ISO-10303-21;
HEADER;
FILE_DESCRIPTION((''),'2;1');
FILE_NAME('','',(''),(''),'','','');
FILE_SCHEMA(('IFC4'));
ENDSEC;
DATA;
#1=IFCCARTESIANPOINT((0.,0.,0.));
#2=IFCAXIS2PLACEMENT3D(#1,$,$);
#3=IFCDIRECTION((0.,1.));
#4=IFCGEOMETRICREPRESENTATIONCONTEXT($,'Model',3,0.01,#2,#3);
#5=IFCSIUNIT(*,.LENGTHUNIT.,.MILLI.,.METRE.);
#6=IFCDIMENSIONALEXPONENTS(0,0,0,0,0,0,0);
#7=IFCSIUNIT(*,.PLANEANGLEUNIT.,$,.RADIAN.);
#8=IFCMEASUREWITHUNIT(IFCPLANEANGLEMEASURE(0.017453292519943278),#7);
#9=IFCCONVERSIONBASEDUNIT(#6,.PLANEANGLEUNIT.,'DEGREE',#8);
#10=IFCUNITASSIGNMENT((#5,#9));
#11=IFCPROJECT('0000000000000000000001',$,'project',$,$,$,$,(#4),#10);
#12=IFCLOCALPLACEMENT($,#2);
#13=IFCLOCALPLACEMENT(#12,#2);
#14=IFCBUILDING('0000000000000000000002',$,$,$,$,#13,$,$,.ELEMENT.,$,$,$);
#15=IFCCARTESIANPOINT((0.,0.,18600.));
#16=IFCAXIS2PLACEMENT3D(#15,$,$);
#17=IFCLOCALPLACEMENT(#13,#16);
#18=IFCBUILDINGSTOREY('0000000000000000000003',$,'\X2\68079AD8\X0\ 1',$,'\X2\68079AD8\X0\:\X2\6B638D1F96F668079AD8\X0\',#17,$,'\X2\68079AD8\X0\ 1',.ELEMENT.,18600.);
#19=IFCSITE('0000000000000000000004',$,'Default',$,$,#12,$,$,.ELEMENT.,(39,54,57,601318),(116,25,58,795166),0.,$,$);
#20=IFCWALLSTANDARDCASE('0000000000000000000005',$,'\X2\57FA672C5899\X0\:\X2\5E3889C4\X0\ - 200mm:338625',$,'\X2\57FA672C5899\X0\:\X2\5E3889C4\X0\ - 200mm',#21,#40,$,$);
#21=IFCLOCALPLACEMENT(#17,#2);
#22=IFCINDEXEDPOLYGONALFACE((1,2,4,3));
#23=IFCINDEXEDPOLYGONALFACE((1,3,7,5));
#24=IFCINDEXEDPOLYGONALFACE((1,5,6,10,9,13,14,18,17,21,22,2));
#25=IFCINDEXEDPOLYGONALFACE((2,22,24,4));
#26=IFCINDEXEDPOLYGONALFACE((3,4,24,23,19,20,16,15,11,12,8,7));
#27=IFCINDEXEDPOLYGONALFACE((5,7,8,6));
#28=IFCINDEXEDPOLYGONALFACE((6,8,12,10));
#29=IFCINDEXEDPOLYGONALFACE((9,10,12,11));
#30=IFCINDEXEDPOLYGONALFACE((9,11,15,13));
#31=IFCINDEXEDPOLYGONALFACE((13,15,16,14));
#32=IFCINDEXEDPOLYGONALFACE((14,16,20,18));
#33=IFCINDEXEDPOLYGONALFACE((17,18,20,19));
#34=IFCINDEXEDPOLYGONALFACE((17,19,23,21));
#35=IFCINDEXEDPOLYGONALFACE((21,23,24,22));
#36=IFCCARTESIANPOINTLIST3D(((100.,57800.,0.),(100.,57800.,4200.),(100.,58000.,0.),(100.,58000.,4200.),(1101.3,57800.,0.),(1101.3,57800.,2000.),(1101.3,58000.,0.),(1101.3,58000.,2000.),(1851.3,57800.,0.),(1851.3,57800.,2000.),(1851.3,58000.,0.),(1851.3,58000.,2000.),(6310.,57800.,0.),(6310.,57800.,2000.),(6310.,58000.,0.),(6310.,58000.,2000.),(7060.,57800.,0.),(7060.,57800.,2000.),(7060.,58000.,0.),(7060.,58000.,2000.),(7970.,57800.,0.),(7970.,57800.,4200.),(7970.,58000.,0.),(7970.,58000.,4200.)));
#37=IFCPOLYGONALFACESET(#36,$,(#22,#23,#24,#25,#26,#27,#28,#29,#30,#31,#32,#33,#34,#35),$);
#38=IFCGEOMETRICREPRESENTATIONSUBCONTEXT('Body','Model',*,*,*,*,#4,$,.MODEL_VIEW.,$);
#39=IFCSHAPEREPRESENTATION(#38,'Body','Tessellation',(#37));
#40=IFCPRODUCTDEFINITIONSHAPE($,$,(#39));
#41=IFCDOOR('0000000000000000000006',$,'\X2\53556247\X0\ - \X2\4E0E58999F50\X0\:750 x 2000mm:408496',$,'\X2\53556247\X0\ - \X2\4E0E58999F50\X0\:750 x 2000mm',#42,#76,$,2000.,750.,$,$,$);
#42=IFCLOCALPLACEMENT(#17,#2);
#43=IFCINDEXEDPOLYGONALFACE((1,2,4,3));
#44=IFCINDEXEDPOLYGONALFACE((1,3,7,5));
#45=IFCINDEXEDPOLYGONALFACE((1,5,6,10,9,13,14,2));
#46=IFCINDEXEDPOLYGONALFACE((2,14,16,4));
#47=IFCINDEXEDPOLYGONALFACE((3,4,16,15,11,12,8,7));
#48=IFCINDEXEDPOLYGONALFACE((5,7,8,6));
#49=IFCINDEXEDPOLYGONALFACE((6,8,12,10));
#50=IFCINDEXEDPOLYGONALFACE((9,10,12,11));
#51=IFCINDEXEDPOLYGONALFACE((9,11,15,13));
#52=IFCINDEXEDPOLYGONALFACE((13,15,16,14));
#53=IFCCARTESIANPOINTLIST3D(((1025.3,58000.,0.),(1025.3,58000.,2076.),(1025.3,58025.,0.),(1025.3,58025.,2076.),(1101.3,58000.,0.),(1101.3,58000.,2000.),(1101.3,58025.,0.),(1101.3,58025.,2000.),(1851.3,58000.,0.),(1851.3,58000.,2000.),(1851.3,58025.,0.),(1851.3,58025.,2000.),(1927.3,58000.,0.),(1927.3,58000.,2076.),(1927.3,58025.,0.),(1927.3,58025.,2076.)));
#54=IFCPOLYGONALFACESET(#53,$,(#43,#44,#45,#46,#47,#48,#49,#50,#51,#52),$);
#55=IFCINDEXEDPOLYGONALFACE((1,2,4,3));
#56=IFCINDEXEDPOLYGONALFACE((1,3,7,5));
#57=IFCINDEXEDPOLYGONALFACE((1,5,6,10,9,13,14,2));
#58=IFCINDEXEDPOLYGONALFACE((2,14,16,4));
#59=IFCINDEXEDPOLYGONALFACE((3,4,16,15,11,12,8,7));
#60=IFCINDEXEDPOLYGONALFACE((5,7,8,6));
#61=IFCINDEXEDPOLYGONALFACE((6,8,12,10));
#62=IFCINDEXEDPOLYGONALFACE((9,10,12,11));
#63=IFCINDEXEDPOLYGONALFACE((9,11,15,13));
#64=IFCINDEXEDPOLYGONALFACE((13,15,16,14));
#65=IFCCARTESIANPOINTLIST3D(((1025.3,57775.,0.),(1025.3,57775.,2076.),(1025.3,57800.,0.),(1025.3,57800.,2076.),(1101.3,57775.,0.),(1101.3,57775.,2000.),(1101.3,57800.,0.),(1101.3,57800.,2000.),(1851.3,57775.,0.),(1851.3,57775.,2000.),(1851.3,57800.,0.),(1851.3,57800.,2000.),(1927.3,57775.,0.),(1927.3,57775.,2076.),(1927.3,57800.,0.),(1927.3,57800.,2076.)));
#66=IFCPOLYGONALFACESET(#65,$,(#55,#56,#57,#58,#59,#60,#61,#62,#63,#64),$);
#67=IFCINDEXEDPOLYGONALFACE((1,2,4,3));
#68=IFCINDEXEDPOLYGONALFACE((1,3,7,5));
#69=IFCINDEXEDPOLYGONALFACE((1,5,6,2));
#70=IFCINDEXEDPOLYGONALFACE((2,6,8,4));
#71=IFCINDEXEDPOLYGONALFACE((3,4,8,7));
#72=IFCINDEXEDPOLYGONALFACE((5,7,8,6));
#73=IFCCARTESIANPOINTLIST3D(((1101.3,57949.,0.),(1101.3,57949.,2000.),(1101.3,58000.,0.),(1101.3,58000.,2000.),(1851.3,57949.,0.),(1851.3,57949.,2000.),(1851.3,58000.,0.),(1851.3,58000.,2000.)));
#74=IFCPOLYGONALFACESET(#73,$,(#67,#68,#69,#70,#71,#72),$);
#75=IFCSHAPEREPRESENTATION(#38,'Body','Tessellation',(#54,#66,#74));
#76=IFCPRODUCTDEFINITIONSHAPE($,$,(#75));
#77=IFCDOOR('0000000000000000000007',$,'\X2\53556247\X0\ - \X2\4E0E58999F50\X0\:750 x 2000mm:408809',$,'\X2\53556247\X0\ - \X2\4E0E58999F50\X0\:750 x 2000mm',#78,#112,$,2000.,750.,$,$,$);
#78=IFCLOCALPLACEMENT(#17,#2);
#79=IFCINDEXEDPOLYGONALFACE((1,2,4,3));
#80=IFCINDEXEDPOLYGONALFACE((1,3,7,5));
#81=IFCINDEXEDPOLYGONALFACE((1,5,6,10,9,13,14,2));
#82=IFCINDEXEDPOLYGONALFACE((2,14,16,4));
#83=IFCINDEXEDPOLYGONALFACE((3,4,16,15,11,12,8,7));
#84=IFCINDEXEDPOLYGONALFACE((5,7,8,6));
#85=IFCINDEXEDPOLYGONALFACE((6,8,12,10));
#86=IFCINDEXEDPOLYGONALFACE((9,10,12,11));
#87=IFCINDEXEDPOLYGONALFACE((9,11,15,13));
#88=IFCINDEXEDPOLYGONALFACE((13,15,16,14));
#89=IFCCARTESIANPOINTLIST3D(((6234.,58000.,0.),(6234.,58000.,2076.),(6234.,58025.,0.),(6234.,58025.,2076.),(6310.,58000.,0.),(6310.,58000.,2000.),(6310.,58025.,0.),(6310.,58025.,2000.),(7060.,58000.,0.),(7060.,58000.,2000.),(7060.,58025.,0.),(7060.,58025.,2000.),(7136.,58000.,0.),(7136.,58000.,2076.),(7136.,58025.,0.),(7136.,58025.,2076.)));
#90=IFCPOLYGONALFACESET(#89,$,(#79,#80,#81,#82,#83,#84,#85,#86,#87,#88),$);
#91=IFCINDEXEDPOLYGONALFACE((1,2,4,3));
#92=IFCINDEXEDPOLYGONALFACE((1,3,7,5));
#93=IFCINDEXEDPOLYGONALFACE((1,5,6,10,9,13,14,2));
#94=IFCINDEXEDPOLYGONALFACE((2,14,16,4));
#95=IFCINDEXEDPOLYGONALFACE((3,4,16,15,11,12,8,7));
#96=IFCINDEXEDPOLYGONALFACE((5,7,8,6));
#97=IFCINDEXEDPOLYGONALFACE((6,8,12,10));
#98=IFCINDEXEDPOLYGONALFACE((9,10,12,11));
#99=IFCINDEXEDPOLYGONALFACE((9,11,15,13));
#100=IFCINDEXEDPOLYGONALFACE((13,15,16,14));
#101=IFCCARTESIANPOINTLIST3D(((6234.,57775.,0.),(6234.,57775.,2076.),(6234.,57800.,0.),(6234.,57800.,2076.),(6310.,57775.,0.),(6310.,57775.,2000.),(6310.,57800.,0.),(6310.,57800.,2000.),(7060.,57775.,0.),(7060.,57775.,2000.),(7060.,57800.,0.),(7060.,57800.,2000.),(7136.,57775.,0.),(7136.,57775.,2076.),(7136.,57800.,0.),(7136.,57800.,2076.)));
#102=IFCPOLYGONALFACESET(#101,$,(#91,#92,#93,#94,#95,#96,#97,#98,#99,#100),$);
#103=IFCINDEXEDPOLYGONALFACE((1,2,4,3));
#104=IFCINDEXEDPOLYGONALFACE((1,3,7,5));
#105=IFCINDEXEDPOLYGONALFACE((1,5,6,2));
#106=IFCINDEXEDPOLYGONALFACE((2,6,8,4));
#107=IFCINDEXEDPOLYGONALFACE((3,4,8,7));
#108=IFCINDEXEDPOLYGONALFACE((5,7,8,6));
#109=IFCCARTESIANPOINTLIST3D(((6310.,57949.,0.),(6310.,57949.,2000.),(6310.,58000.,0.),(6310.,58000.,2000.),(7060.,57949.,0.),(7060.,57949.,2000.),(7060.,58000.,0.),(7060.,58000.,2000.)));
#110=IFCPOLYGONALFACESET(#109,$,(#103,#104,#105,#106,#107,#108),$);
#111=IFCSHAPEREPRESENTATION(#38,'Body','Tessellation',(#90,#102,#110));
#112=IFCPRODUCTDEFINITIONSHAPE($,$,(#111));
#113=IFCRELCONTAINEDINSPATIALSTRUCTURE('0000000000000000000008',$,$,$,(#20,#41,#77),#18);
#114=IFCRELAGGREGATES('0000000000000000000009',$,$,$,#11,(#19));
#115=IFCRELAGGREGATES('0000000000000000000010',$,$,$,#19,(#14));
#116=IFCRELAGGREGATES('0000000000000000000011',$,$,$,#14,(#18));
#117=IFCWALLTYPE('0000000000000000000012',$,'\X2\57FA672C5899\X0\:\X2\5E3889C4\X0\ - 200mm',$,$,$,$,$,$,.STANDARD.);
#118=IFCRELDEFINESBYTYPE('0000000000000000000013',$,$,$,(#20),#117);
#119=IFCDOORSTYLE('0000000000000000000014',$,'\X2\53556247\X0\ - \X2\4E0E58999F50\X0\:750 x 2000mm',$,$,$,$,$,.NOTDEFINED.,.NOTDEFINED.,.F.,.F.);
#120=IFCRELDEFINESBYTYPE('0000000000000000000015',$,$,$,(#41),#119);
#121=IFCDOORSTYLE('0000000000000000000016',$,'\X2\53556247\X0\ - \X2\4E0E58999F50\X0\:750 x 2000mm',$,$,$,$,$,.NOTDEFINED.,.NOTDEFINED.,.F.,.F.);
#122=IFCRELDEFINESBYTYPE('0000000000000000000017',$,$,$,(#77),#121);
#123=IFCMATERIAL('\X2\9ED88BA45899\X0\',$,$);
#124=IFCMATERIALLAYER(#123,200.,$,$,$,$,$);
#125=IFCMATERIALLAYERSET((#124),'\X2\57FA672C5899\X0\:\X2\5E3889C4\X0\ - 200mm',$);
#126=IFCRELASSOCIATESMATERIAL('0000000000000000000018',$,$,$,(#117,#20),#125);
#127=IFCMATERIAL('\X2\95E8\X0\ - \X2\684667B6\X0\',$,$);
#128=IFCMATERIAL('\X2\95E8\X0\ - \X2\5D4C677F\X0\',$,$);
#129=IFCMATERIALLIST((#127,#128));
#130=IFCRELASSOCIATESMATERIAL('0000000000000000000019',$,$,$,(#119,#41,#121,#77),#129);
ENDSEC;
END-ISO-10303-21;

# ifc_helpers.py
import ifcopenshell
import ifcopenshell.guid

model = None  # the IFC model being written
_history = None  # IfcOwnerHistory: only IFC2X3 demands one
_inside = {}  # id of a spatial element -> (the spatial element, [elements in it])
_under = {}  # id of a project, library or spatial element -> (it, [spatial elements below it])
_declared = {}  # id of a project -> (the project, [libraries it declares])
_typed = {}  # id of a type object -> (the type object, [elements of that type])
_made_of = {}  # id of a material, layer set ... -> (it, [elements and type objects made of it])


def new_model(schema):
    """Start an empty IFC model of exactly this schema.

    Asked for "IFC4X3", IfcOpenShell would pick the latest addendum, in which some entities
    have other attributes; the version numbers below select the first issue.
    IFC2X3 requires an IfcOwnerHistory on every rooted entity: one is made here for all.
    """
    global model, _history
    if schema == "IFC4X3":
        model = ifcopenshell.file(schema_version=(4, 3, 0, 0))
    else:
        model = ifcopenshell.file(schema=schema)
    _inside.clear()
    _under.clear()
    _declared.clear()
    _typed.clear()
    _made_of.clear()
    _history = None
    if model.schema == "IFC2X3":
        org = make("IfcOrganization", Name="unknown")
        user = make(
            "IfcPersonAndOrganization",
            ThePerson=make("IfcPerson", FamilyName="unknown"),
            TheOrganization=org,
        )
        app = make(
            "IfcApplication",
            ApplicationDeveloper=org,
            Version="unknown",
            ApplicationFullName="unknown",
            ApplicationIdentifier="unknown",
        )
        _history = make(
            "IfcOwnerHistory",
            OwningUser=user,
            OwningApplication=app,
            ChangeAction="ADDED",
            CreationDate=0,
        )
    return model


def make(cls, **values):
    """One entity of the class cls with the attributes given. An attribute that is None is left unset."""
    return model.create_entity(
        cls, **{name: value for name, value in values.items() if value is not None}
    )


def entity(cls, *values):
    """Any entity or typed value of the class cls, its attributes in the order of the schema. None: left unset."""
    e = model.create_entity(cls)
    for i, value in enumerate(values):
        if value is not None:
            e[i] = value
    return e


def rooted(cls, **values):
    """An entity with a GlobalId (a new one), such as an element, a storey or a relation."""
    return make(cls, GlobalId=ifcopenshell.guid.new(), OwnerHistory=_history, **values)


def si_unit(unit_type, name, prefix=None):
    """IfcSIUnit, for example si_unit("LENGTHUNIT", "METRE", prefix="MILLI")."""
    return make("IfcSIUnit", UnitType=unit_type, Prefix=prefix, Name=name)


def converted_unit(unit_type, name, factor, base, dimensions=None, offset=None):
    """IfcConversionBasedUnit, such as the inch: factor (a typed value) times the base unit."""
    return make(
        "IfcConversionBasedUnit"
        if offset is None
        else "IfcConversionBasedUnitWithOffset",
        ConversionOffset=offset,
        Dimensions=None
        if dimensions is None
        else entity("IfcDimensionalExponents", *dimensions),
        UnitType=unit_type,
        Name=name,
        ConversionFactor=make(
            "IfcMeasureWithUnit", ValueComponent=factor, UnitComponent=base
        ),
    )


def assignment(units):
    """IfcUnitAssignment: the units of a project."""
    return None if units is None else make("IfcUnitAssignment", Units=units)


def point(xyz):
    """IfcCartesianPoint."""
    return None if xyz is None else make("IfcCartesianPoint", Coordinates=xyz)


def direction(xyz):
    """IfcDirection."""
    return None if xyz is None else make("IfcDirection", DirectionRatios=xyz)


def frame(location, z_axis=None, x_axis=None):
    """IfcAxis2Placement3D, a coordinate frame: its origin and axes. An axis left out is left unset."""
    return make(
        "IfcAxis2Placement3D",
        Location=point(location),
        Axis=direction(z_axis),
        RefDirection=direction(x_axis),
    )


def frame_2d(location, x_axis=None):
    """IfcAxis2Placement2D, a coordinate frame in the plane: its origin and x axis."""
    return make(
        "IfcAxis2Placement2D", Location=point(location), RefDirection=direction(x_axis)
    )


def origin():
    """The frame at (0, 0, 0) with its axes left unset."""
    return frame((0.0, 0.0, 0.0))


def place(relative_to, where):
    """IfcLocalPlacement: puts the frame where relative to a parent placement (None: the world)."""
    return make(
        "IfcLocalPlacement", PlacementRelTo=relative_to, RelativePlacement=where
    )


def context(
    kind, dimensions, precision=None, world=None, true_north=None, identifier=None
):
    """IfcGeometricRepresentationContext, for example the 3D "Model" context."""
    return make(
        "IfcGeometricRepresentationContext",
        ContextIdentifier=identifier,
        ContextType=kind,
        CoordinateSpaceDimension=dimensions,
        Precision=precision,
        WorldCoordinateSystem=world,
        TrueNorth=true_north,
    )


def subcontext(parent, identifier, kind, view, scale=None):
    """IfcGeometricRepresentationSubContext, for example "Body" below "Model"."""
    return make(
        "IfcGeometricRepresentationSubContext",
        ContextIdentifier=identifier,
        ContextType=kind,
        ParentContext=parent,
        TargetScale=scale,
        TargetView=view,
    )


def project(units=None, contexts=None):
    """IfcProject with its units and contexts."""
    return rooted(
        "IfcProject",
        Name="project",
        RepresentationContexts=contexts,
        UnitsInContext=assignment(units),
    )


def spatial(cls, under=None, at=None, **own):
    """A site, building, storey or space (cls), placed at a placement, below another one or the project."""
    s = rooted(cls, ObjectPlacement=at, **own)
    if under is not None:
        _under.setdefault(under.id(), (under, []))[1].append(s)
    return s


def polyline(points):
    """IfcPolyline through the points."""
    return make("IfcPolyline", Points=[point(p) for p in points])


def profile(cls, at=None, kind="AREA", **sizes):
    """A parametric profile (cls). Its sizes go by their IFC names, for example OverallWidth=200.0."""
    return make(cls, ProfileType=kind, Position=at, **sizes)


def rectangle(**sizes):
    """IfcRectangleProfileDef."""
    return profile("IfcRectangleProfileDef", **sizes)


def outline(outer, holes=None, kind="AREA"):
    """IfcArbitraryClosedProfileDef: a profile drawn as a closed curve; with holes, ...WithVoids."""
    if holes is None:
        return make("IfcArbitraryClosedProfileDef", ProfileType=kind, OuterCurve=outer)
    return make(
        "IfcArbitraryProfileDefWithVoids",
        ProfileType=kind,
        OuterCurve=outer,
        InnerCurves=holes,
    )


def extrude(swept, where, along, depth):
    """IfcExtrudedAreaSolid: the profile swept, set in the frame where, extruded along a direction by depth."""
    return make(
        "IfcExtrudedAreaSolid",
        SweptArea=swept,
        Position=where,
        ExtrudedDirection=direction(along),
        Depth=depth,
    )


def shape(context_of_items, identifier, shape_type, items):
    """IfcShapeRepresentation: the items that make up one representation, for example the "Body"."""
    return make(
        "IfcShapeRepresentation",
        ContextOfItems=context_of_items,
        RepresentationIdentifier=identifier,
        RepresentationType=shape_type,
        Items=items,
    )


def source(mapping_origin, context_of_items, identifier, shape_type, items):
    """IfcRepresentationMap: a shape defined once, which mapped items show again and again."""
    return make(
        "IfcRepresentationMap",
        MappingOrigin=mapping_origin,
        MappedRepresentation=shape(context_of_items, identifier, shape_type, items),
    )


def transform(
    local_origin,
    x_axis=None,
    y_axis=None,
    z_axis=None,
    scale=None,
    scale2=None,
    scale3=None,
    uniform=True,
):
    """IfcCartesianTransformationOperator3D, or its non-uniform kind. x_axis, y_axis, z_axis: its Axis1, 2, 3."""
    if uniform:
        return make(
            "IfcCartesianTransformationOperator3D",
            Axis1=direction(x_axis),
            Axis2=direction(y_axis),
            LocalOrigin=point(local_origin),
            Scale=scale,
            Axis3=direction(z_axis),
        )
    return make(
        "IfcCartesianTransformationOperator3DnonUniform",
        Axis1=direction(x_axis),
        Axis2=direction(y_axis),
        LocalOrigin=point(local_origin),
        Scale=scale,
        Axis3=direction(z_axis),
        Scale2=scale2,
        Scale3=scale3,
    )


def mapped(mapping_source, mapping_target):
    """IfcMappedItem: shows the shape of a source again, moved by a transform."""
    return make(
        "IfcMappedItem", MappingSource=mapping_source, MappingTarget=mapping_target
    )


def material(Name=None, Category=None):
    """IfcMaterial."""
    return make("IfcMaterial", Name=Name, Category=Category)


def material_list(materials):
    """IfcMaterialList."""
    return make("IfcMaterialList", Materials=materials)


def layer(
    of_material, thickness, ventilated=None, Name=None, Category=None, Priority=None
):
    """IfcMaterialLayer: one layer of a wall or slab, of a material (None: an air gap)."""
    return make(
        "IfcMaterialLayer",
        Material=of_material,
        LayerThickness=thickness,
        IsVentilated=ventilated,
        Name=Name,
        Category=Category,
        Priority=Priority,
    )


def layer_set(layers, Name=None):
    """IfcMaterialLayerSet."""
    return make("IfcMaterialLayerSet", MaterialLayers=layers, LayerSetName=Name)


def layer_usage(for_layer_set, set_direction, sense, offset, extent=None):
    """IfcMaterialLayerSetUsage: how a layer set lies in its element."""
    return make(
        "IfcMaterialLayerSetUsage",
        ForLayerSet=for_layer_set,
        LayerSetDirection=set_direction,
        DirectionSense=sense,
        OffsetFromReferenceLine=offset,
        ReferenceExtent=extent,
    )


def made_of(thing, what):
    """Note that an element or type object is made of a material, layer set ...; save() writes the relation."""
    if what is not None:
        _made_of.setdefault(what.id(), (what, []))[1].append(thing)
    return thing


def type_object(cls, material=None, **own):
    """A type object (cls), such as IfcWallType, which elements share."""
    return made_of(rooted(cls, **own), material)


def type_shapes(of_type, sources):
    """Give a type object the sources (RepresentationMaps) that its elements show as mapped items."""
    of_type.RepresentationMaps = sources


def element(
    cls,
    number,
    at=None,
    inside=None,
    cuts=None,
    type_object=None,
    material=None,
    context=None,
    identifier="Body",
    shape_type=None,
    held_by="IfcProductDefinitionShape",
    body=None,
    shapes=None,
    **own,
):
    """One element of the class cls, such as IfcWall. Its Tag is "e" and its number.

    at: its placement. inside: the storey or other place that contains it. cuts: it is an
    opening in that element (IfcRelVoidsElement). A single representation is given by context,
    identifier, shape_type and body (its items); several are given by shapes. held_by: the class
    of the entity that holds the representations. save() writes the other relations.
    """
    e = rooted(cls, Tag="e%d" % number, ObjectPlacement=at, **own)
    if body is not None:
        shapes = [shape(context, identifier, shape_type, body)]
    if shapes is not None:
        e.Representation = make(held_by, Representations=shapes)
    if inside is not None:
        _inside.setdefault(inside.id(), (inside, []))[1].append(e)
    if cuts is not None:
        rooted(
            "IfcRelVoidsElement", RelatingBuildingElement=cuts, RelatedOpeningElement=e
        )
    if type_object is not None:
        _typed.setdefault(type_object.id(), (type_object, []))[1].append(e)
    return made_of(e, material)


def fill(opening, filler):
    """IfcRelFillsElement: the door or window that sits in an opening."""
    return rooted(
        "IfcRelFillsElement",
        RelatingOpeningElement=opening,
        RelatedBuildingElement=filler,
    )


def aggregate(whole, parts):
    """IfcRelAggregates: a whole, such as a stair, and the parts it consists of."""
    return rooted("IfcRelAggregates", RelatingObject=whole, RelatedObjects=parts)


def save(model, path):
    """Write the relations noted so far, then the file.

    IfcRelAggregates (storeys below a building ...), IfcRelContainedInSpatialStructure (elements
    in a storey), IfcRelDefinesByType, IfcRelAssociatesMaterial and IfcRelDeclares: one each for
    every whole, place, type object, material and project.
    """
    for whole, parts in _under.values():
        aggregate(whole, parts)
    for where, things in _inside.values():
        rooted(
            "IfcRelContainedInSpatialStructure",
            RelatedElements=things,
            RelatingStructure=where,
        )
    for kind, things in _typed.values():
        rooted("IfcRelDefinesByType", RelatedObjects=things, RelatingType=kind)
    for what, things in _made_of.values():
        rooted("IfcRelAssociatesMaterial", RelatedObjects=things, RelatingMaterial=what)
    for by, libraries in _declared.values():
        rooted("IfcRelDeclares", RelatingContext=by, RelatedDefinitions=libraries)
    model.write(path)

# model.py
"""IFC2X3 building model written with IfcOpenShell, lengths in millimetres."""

from ifc_helpers import new_model, entity, si_unit, converted_unit, direction, frame, frame_2d, origin, place, context, subcontext, project, spatial, polyline, rectangle, outline, extrude, source, transform, mapped, material, material_list, layer, layer_set, layer_usage, type_object, type_shapes, element, fill, save


model = new_model("IFC2X3")

# Units and contexts
model_context = context("Model", 3, precision=0.01, world=origin(), true_north=direction((0.0, 1.0)))
body_context = subcontext(model_context, "Body", "Model", "MODEL_VIEW")
ifc_project = project(units=[si_unit("LENGTHUNIT", "METRE", prefix="MILLI"), converted_unit("PLANEANGLEUNIT", "DEGREE", entity("IfcPlaneAngleMeasure", 0.017453292519943278), si_unit("PLANEANGLEUNIT", "RADIAN"), dimensions=[0, 0, 0, 0, 0, 0, 0])], contexts=[model_context])

# Site, building, storey
site_placement = place(None, origin())
site = spatial("IfcSite", under=ifc_project, at=site_placement, Name="Default", CompositionType="ELEMENT", RefLatitude=(39, 54, 57, 601318), RefLongitude=(116, 25, 58, 795166), RefElevation=0.0)
building_placement = place(site_placement, origin())
building = spatial("IfcBuilding", under=site, at=building_placement, CompositionType="ELEMENT")
storey_placement = place(building_placement, frame((0.0, 0.0, 18600.0)))
storey = spatial("IfcBuildingStorey", under=building, at=storey_placement, Name="标高 1", ObjectType="标高:正负零标高", LongName="标高 1", CompositionType="ELEMENT", Elevation=18600.0)

# Shared definitions
ifc_material_1 = material(Name="默认墙")
ifc_layer = layer(ifc_material_1, 200.0)
ifc_layer_set = layer_set([ifc_layer], Name="基本墙:常规 - 200mm")
wall_type = type_object("IfcWallType", Name="基本墙:常规 - 200mm", PredefinedType="STANDARD", material=ifc_layer_set)

# Wall, openings, doors
ifc_layer_usage_1 = layer_usage(ifc_layer_set, "AXIS2", "NEGATIVE", 100.0)
wall_1_placement = place(storey_placement, frame((7970.0, 57900.0, 0.0), z_axis=(0.0, 0.0, 1.0), x_axis=(-1.0, 0.0, 0.0)))
wall_1 = element("IfcWallStandardCase", 1, at=wall_1_placement, inside=storey, type_object=wall_type, material=ifc_layer_usage_1, Name="基本墙:常规 - 200mm:338625", ObjectType="基本墙:常规 - 200mm", context=body_context, shape_type="SweptSolid", body=[
    extrude(rectangle(XDim=7870.0, YDim=200.0, at=frame_2d((3935.0, 0.0), x_axis=(-1.0, 0.0))), origin(), (0.0, 0.0, 1.0), 4200.0),
])
opening_1_placement = place(wall_1_placement, frame((6868.8, 100.0, 0.0)))
opening_1 = element("IfcOpeningElement", 2, at=opening_1_placement, cuts=wall_1, ObjectType="Opening", context=body_context, shape_type="SweptSolid", body=[
    extrude(rectangle(XDim=750.0, YDim=2000.0, at=frame_2d((1000.0, 375.0), x_axis=(0.0, -1.0))), frame((0.0, 0.0, 0.0), z_axis=(0.0, -1.0, 0.0), x_axis=(0.0, 0.0, 1.0)), (0.0, 0.0, 1.0), 200.0),
])
opening_2_placement = place(wall_1_placement, frame((1660.0, 100.0, 0.0)))
opening_2 = element("IfcOpeningElement", 3, at=opening_2_placement, cuts=wall_1, ObjectType="Opening", context=body_context, shape_type="SweptSolid", body=[
    extrude(rectangle(XDim=750.0, YDim=2000.0, at=frame_2d((1000.0, 375.0), x_axis=(0.0, 1.0))), frame((0.0, 0.0, 0.0), z_axis=(0.0, -1.0, 0.0), x_axis=(0.0, 0.0, 1.0)), (0.0, 0.0, 1.0), 200.0),
])
ifc_material_2 = material(Name="门 - 框架")
ifc_material_3 = material(Name="门 - 嵌板")
ifc_material_list_1 = material_list([ifc_material_2, ifc_material_3])
door_style_1 = type_object("IfcDoorStyle", Name="单扇 - 与墙齐:750 x 2000mm", ConstructionType="NOTDEFINED", OperationType="NOTDEFINED", ParameterTakesPrecedence=False, Sizeable=False, material=ifc_material_list_1)
shared_shape_1 = source(origin(), body_context, "Body", "SweptSolid", [
    extrude(outline(polyline([(-451.0, -1057.0), (451.0, -1057.0), (451.0, 1019.0), (375.0, 1019.0), (375.0, -981.0), (-375.0, -981.0), (-375.0, 1019.0), (-451.0, 1019.0), (-451.0, -1057.0)])), frame((375.0, 225.0, 1019.0), z_axis=(0.0, -1.0, 0.0), x_axis=(-1.0, 0.0, 0.0)), (0.0, 0.0, 1.0), 25.0),
    extrude(outline(polyline([(-1057.0, -451.0), (1019.0, -451.0), (1019.0, -375.0), (-981.0, -375.0), (-981.0, 375.0), (1019.0, 375.0), (1019.0, 451.0), (-1057.0, 451.0), (-1057.0, -451.0)])), frame((375.0, 0.0, 1019.0), z_axis=(0.0, -1.0, 0.0), x_axis=(0.0, 0.0, -1.0)), (0.0, 0.0, 1.0), 25.0),
    extrude(rectangle(XDim=750.0, YDim=51.0, at=frame_2d((0.0, 0.0), x_axis=(1.0, 0.0))), frame((375.0, 174.5, 0.0)), (0.0, 0.0, 1.0), 2000.0),
])
type_shapes(door_style_1, [shared_shape_1])
door_1_placement = place(opening_1_placement, frame((0.0, 0.0, 0.0), z_axis=(0.0, 0.0, 1.0), x_axis=(-1.0, 0.0, 0.0)))
door_1 = element("IfcDoor", 4, at=door_1_placement, inside=storey, type_object=door_style_1, material=ifc_material_list_1, Name="单扇 - 与墙齐:750 x 2000mm:408496", ObjectType="单扇 - 与墙齐:750 x 2000mm", OverallHeight=2000.0, OverallWidth=750.0, context=body_context, shape_type="MappedRepresentation", body=[
    mapped(shared_shape_1, transform((0.0, 0.0, 0.0), scale=1.0)),
])
fill(opening_1, door_1)
door_style_2 = type_object("IfcDoorStyle", Name="单扇 - 与墙齐:750 x 2000mm", ConstructionType="NOTDEFINED", OperationType="NOTDEFINED", ParameterTakesPrecedence=False, Sizeable=False, material=ifc_material_list_1)
shared_shape_2 = source(origin(), body_context, "Body", "SweptSolid", [
    extrude(outline(polyline([(-451.0, -1057.0), (451.0, -1057.0), (451.0, 1019.0), (375.0, 1019.0), (375.0, -981.0), (-375.0, -981.0), (-375.0, 1019.0), (-451.0, 1019.0), (-451.0, -1057.0)])), frame((375.0, 200.0, 1019.0), z_axis=(0.0, 1.0, 0.0), x_axis=(1.0, 0.0, 0.0)), (0.0, 0.0, 1.0), 25.0),
    extrude(outline(polyline([(-1057.0, -451.0), (1019.0, -451.0), (1019.0, -375.0), (-981.0, -375.0), (-981.0, 375.0), (1019.0, 375.0), (1019.0, 451.0), (-1057.0, 451.0), (-1057.0, -451.0)])), frame((375.0, -25.0, 1019.0), z_axis=(0.0, 1.0, 0.0), x_axis=(0.0, 0.0, -1.0)), (0.0, 0.0, 1.0), 25.0),
    extrude(rectangle(XDim=51.0, YDim=750.0, at=frame_2d((0.0, 0.0), x_axis=(1.0, 0.0))), frame((375.0, 174.5, 0.0), z_axis=(0.0, 0.0, 1.0), x_axis=(0.0, 1.0, 0.0)), (0.0, 0.0, 1.0), 2000.0),
])
type_shapes(door_style_2, [shared_shape_2])
door_2_placement = place(opening_2_placement, frame((0.0, 0.0, 0.0), z_axis=(0.0, 0.0, 1.0), x_axis=(-1.0, 0.0, 0.0)))
door_2 = element("IfcDoor", 5, at=door_2_placement, inside=storey, type_object=door_style_2, material=ifc_material_list_1, Name="单扇 - 与墙齐:750 x 2000mm:408809", ObjectType="单扇 - 与墙齐:750 x 2000mm", OverallHeight=2000.0, OverallWidth=750.0, context=body_context, shape_type="MappedRepresentation", body=[
    mapped(shared_shape_2, transform((0.0, 0.0, 0.0), scale=1.0)),
])
fill(opening_2, door_2)

save(model, "model.ifc")
